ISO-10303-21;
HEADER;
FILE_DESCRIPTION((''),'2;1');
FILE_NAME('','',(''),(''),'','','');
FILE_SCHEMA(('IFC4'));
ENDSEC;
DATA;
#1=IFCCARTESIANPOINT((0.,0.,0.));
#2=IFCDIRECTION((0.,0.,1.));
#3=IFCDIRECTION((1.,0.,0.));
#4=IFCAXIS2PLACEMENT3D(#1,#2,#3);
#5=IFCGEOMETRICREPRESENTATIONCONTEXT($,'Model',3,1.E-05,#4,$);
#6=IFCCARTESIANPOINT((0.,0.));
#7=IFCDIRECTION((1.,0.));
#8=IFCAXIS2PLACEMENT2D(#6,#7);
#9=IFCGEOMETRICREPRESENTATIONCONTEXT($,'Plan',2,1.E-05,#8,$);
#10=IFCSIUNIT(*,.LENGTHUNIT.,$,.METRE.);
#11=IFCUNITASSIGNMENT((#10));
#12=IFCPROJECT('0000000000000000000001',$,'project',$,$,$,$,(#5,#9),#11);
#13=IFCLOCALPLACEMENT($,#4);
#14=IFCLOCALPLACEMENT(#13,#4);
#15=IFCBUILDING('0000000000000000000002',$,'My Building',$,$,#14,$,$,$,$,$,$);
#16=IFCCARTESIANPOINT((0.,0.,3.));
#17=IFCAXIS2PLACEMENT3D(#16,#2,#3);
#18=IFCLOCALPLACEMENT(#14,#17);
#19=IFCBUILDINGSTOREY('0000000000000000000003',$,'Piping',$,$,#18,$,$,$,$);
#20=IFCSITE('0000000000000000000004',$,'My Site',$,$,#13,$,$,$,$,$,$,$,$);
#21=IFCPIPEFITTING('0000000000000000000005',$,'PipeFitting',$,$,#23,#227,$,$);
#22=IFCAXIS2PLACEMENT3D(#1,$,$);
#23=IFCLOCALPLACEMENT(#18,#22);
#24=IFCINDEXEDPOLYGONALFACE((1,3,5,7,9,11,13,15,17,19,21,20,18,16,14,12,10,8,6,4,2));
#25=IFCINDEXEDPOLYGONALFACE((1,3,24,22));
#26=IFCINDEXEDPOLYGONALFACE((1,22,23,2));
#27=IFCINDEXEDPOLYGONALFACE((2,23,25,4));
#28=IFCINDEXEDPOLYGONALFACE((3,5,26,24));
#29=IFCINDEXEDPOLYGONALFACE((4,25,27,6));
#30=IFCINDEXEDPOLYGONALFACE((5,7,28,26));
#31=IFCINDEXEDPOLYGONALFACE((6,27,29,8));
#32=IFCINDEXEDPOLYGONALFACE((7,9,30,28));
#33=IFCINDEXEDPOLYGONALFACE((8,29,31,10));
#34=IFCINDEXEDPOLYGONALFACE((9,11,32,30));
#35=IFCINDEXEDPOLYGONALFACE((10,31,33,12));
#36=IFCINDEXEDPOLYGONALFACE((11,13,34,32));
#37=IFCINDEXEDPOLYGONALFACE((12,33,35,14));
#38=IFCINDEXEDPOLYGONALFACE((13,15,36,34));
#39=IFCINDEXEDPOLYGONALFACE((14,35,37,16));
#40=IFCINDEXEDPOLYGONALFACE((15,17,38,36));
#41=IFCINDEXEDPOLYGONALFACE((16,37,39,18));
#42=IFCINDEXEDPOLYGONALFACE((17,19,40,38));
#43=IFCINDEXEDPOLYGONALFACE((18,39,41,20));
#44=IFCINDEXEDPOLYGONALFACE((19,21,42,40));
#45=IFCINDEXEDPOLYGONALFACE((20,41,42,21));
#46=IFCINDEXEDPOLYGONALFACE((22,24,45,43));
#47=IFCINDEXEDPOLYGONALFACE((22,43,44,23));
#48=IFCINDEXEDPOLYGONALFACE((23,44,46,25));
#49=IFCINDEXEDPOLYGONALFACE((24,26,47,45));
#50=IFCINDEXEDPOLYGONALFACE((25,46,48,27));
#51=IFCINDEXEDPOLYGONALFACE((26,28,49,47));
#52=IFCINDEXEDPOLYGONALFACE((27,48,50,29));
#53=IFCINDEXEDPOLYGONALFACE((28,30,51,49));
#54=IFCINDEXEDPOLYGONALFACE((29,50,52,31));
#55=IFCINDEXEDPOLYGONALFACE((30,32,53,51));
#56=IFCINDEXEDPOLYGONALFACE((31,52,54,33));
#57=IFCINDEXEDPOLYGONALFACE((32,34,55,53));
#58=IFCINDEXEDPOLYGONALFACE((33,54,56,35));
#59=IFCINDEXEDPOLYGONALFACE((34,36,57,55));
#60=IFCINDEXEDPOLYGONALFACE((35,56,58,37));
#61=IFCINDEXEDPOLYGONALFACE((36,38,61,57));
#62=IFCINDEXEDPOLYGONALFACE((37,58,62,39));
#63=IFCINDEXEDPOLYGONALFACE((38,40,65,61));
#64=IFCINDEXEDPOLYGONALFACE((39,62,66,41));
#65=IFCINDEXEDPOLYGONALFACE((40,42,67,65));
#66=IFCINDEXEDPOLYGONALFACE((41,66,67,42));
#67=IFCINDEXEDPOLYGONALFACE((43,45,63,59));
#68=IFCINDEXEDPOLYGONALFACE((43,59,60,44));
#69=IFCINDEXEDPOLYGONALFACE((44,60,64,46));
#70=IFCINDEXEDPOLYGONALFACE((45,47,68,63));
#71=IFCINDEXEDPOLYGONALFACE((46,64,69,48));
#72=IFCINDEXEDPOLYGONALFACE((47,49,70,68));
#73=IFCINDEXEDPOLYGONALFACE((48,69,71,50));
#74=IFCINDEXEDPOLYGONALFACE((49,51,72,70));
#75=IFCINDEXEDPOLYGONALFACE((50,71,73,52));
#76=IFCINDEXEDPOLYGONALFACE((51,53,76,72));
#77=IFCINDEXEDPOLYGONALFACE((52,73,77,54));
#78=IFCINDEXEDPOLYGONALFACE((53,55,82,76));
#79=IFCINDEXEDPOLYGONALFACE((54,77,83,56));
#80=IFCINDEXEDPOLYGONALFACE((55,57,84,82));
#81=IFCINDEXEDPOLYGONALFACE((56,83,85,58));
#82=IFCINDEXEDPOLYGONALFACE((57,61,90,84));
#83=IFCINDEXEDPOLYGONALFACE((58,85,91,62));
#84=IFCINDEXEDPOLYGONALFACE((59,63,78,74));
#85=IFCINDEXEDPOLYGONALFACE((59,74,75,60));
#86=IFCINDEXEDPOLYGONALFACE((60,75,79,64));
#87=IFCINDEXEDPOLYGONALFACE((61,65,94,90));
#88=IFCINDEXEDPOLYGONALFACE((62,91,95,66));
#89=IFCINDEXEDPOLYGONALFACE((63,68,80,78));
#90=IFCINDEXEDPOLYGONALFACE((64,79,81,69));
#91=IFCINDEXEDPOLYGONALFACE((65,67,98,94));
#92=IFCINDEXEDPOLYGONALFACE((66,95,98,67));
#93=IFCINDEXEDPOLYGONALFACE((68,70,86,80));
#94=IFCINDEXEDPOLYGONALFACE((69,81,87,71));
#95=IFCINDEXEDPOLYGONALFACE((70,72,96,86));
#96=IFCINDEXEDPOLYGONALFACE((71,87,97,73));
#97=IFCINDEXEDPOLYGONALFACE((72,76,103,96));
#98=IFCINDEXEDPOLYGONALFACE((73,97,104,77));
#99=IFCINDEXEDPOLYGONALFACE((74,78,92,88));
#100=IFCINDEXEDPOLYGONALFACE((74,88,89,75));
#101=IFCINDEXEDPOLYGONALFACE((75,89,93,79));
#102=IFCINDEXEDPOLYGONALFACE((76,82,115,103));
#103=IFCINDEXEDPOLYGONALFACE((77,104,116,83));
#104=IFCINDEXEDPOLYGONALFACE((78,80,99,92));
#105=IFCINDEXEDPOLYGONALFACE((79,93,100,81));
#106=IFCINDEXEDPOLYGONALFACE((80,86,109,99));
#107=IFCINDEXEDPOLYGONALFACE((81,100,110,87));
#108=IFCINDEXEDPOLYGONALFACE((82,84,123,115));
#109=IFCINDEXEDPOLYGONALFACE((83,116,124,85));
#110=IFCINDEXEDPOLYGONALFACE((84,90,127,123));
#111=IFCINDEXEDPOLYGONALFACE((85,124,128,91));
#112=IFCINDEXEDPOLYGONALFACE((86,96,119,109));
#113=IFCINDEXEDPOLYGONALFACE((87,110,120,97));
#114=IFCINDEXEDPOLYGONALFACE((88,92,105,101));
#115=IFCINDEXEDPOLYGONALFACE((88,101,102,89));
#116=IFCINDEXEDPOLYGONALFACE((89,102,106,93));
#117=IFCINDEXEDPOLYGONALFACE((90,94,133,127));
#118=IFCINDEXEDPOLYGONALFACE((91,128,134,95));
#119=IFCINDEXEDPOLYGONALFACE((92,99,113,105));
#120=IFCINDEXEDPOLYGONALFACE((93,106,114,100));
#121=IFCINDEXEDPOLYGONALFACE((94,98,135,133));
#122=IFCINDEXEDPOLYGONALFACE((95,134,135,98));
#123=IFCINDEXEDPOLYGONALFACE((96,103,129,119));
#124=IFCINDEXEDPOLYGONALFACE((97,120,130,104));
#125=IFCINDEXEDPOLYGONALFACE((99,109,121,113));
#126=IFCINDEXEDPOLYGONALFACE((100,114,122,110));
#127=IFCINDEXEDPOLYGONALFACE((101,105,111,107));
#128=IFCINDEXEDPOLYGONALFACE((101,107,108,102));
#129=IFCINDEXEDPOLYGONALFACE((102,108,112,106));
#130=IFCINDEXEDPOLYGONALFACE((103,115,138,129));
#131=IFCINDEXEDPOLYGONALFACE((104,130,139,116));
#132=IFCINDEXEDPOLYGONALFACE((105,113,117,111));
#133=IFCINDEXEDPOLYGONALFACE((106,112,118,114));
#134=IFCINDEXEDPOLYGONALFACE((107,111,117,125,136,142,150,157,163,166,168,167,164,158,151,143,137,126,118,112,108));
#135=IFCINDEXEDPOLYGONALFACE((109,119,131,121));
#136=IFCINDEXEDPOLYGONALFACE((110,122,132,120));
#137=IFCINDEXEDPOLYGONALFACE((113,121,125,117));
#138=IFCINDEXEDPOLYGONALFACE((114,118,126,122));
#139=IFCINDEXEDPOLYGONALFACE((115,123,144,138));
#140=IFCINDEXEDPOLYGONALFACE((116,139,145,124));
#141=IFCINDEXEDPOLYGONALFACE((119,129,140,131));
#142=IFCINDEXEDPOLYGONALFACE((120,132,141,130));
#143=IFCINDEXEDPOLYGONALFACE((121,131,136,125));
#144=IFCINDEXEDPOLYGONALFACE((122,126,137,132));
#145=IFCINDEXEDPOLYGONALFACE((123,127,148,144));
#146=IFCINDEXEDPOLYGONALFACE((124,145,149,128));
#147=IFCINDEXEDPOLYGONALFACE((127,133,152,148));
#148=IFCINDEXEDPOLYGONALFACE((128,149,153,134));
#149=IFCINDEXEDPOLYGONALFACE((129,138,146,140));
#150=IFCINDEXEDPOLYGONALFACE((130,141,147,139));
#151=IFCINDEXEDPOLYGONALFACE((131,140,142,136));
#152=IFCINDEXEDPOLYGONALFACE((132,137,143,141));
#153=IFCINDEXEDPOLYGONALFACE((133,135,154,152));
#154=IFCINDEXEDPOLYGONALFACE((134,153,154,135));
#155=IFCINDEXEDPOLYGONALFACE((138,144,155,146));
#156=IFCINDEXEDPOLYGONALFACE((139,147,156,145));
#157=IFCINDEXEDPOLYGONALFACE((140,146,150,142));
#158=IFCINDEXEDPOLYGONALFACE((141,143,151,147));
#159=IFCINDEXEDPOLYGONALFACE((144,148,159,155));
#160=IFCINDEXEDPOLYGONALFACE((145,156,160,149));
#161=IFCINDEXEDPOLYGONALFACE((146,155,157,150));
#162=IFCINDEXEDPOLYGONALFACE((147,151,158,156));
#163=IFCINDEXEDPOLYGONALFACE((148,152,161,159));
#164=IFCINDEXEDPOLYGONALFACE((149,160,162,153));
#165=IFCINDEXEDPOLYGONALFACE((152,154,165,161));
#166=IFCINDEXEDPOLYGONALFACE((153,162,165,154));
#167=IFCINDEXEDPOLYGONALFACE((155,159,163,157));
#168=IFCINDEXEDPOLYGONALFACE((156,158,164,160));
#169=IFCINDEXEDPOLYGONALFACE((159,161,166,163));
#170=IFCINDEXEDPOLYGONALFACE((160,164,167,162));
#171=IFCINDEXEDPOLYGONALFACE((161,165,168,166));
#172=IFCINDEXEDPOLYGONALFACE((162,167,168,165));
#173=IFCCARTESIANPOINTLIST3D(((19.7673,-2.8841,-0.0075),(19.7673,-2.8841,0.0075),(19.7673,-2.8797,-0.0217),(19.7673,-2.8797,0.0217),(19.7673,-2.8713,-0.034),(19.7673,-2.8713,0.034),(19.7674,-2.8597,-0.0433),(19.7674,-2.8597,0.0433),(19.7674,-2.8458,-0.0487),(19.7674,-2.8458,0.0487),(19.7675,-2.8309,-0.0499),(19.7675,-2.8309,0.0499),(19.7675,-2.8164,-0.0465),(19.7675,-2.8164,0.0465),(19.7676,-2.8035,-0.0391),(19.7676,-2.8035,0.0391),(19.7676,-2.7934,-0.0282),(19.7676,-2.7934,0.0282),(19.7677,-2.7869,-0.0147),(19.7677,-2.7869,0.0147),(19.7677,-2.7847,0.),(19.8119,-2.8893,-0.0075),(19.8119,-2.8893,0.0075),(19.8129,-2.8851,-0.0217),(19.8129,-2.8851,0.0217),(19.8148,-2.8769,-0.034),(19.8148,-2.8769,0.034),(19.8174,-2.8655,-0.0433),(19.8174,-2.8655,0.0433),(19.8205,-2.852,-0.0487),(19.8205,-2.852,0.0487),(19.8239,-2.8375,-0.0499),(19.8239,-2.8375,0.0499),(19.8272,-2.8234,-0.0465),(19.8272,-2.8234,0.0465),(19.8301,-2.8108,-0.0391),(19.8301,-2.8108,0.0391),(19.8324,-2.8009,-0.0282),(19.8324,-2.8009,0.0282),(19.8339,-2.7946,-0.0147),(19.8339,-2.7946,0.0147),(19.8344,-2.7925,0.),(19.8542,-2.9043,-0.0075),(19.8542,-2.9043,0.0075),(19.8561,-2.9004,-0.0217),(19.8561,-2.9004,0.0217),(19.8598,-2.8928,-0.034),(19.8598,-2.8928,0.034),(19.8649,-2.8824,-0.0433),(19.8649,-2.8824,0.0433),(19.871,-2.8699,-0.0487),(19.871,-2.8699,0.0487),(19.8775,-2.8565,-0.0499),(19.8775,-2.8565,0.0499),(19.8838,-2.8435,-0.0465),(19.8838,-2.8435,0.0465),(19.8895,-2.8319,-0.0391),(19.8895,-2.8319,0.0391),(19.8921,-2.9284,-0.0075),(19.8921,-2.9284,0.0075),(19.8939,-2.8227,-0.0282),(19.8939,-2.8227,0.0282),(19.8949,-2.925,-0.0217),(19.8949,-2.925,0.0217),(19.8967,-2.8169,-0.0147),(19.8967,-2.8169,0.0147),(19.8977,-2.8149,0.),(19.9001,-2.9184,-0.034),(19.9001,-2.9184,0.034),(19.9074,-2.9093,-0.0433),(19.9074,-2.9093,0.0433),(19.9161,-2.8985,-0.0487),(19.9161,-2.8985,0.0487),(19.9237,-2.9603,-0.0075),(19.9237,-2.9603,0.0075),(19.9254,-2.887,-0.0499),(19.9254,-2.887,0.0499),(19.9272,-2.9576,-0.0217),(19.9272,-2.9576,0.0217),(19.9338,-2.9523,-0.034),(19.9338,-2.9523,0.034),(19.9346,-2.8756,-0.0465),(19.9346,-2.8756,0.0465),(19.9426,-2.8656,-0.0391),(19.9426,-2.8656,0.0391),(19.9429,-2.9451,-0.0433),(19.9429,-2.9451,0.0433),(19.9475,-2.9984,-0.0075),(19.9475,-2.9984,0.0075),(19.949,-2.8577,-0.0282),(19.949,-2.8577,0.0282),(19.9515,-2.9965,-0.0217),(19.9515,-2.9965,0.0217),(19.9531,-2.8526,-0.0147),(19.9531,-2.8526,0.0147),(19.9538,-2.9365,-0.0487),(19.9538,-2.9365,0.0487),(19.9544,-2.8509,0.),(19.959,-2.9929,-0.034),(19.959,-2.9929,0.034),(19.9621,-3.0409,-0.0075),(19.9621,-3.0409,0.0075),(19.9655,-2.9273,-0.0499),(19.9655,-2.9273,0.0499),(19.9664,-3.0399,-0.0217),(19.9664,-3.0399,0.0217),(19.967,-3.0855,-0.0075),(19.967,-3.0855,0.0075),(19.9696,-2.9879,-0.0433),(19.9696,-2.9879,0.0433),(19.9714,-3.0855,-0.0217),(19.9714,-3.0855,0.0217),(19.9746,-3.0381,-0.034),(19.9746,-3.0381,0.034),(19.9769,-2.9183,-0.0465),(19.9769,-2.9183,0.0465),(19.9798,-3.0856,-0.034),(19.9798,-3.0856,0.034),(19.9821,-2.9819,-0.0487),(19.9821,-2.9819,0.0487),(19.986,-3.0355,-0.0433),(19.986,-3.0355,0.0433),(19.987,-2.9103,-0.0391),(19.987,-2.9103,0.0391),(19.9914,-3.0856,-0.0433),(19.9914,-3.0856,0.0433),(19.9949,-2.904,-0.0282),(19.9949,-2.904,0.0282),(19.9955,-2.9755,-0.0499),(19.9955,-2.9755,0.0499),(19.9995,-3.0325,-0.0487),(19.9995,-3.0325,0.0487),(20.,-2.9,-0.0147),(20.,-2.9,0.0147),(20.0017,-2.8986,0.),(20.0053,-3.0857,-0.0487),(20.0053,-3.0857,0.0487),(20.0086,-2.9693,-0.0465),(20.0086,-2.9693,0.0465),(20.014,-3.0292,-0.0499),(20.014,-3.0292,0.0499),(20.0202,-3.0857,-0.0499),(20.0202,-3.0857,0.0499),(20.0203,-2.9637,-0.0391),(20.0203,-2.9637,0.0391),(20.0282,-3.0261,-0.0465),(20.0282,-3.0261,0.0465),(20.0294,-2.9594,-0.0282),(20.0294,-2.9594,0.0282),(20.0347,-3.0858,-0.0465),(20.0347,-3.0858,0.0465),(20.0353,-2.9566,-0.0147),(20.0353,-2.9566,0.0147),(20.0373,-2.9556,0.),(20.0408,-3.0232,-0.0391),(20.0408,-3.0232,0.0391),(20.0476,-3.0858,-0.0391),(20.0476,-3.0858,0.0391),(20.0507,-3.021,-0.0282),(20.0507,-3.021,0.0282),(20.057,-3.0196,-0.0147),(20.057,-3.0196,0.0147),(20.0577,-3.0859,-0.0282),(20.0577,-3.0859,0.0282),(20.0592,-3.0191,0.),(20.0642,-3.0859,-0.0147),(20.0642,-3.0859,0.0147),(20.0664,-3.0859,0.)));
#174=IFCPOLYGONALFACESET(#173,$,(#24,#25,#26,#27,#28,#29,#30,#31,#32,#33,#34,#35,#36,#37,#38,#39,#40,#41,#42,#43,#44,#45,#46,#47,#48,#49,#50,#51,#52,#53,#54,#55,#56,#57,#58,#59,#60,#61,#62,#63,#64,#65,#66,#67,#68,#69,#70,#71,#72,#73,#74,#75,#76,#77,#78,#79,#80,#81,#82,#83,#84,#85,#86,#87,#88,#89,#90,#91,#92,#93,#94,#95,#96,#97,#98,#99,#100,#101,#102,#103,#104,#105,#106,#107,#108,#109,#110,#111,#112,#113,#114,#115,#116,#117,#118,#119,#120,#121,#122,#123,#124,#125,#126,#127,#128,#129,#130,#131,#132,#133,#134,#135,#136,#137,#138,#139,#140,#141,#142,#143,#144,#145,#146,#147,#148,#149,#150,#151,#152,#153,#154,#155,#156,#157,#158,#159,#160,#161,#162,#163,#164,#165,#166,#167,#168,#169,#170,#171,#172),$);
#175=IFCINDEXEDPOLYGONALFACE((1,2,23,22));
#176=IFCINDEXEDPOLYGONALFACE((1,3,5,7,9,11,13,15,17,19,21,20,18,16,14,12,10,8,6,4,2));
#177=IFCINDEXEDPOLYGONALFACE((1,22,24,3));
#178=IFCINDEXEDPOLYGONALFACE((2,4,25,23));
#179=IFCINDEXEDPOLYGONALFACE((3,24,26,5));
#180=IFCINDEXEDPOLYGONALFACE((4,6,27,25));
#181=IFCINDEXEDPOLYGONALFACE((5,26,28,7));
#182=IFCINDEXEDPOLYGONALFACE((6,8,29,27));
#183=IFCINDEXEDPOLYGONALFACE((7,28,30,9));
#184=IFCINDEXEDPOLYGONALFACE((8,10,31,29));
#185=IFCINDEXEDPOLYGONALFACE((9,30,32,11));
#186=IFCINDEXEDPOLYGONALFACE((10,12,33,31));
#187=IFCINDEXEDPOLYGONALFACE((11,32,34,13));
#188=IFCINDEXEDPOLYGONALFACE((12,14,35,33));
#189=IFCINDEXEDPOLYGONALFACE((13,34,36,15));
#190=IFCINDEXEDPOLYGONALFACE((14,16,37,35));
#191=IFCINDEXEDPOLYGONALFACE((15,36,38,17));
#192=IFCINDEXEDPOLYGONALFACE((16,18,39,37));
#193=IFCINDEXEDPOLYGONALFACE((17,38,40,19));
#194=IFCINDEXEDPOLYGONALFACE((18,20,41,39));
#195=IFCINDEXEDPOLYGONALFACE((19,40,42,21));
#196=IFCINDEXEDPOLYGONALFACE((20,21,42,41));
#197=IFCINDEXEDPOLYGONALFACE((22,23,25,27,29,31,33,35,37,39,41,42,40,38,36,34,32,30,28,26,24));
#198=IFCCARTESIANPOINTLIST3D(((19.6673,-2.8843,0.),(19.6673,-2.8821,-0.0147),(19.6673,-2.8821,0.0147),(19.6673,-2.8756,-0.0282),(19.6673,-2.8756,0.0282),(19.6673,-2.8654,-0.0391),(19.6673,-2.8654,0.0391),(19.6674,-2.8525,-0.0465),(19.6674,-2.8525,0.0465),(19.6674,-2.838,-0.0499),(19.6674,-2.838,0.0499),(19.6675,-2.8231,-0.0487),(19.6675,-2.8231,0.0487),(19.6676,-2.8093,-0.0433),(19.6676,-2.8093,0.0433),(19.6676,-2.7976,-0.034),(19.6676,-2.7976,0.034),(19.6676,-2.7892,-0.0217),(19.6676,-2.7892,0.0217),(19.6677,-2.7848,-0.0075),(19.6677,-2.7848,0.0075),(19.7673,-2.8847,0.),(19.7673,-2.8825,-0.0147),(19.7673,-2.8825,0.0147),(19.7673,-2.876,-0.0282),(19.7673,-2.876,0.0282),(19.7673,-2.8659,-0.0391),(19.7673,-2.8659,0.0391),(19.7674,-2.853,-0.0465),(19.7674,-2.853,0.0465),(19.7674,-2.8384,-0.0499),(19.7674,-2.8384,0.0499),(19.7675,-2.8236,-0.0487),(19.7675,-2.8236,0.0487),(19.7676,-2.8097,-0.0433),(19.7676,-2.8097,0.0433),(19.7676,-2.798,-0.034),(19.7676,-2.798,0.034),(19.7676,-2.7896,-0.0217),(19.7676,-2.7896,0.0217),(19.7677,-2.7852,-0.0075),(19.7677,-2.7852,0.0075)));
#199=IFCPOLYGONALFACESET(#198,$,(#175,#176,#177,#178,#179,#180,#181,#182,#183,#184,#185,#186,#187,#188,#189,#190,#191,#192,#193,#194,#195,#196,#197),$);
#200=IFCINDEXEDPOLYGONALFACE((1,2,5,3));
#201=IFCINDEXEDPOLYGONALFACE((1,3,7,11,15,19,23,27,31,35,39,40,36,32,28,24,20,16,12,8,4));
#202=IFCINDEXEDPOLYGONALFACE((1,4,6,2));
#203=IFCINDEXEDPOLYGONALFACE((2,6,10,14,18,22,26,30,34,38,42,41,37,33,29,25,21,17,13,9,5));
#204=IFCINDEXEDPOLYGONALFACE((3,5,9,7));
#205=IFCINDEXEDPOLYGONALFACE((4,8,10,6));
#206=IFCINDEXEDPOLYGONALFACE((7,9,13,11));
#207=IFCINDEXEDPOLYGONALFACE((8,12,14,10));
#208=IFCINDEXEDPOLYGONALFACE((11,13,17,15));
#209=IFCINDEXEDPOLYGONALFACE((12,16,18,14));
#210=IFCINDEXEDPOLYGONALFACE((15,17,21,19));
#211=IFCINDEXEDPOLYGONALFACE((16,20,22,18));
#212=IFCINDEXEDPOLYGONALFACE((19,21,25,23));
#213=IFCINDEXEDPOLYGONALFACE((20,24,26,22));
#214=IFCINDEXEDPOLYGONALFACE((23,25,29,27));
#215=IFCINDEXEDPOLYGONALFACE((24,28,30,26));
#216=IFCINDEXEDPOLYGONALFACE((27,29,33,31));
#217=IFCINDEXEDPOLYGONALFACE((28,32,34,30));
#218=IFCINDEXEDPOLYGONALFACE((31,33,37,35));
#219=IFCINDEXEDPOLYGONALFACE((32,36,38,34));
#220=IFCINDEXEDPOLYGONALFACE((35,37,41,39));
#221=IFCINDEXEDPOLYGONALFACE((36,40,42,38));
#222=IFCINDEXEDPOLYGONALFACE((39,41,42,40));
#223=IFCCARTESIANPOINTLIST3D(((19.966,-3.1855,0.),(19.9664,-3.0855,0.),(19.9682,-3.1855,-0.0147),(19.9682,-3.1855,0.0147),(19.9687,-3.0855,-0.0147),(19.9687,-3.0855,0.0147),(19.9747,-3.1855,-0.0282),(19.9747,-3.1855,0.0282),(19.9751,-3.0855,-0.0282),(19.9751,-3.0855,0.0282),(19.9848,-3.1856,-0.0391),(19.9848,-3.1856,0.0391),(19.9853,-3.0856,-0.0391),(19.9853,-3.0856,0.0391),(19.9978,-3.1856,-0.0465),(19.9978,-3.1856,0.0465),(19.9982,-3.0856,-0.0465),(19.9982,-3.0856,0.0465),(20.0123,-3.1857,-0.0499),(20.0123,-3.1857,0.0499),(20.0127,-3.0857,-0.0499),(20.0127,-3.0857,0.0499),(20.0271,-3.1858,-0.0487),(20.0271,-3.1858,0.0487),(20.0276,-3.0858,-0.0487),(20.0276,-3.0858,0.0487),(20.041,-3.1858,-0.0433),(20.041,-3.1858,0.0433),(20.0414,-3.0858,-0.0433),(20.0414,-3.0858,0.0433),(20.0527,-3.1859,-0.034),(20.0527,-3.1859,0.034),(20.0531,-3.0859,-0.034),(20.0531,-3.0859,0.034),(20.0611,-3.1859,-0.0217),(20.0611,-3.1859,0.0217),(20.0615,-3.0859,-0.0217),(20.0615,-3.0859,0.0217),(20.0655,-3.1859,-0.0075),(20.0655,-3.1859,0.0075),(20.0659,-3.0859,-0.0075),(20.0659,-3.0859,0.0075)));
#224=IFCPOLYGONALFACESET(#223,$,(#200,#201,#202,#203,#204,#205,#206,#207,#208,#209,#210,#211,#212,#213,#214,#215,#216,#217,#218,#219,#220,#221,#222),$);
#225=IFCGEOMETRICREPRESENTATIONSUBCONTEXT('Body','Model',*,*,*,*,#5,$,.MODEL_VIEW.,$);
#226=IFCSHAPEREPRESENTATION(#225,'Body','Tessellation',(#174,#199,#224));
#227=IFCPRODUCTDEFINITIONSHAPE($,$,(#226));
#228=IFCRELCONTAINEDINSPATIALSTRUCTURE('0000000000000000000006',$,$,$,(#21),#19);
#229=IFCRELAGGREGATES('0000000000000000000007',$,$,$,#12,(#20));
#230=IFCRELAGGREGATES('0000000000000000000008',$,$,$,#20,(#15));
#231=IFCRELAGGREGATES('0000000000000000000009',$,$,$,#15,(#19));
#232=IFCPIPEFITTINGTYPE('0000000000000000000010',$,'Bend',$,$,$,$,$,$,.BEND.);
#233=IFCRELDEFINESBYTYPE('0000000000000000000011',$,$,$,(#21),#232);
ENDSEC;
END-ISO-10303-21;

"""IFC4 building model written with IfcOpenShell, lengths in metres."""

from ifc_helpers import new_model, entity, si_unit, frame, origin_with_axes, origin_2d_with_axis, place, context, subcontext, project, spatial, circle, extrude, source, transform, mapped, type_object, type_shapes, element, save


model = new_model("IFC4")

# Units and contexts
model_context = context("Model", 3, precision=1e-05, world=origin_with_axes())
plan_context = context("Plan", 2, precision=1e-05, world=origin_2d_with_axis())
body_context = subcontext(model_context, "Body", "Model", "MODEL_VIEW")
ifc_project = project(units=[si_unit("LENGTHUNIT", "METRE")], contexts=[model_context, plan_context])

# Site, building, storey
site_placement = place(None, origin_with_axes())
site = spatial("IfcSite", under=ifc_project, at=site_placement, Name="My Site")
building_placement = place(site_placement, origin_with_axes())
building = spatial("IfcBuilding", under=site, at=building_placement, Name="My Building")
storey_placement = place(building_placement, frame((0.0, 0.0, 3.0), z_axis=(0.0, 0.0, 1.0), x_axis=(1.0, 0.0, 0.0)))
storey = spatial("IfcBuildingStorey", under=building, at=storey_placement, Name="Piping")

# Pipe fitting
pipe_fitting_type_1 = type_object("IfcPipeFittingType", Name="Bend", PredefinedType="BEND")
shared_shape_1 = source(origin_with_axes(), body_context, "Body", "SolidModel", [
    entity("IfcSweptDiskSolid", entity("IfcIndexedPolyCurve", entity("IfcCartesianPointList3D", [[0.0, 0.0, -0.1], [0.0732, 0.0, -0.2768], [0.25, 0.0, -0.35]]), [entity("IfcArcIndex", [1, 2, 3])]), 0.05),
    extrude(circle(Radius=0.05), origin_with_axes(), (0.0, 0.0, -1.0), 0.1),
    extrude(circle(Radius=0.05), frame((0.25, 0.0, -0.35), z_axis=(1.0, 0.0, 0.0), x_axis=(0.0, 0.0, 1.0)), (0.0, 0.0, 1.0), 0.1),
])
type_shapes(pipe_fitting_type_1, [shared_shape_1])
for number, where, z_axis, x_axis, name in (
    (1, (19.6675, -2.8343, 0.0), (-0.999992, 0.004102, 0.0), (-0.004102, -0.999992, 0.0), "PipeFitting"),
):
    element("IfcPipeFitting", number, at=place(storey_placement, frame(where, z_axis=z_axis, x_axis=x_axis)), inside=storey, type_object=pipe_fitting_type_1, Name=name, context=body_context, shape_type="MappedRepresentation", body=[
        mapped(shared_shape_1, transform((0.0, 0.0, 0.0), x_axis=(1.0, 0.0, 0.0), y_axis=(0.0, 1.0, 0.0), z_axis=(0.0, 0.0, 1.0), scale=1.0)),
    ])

save(model, "model.ifc")
